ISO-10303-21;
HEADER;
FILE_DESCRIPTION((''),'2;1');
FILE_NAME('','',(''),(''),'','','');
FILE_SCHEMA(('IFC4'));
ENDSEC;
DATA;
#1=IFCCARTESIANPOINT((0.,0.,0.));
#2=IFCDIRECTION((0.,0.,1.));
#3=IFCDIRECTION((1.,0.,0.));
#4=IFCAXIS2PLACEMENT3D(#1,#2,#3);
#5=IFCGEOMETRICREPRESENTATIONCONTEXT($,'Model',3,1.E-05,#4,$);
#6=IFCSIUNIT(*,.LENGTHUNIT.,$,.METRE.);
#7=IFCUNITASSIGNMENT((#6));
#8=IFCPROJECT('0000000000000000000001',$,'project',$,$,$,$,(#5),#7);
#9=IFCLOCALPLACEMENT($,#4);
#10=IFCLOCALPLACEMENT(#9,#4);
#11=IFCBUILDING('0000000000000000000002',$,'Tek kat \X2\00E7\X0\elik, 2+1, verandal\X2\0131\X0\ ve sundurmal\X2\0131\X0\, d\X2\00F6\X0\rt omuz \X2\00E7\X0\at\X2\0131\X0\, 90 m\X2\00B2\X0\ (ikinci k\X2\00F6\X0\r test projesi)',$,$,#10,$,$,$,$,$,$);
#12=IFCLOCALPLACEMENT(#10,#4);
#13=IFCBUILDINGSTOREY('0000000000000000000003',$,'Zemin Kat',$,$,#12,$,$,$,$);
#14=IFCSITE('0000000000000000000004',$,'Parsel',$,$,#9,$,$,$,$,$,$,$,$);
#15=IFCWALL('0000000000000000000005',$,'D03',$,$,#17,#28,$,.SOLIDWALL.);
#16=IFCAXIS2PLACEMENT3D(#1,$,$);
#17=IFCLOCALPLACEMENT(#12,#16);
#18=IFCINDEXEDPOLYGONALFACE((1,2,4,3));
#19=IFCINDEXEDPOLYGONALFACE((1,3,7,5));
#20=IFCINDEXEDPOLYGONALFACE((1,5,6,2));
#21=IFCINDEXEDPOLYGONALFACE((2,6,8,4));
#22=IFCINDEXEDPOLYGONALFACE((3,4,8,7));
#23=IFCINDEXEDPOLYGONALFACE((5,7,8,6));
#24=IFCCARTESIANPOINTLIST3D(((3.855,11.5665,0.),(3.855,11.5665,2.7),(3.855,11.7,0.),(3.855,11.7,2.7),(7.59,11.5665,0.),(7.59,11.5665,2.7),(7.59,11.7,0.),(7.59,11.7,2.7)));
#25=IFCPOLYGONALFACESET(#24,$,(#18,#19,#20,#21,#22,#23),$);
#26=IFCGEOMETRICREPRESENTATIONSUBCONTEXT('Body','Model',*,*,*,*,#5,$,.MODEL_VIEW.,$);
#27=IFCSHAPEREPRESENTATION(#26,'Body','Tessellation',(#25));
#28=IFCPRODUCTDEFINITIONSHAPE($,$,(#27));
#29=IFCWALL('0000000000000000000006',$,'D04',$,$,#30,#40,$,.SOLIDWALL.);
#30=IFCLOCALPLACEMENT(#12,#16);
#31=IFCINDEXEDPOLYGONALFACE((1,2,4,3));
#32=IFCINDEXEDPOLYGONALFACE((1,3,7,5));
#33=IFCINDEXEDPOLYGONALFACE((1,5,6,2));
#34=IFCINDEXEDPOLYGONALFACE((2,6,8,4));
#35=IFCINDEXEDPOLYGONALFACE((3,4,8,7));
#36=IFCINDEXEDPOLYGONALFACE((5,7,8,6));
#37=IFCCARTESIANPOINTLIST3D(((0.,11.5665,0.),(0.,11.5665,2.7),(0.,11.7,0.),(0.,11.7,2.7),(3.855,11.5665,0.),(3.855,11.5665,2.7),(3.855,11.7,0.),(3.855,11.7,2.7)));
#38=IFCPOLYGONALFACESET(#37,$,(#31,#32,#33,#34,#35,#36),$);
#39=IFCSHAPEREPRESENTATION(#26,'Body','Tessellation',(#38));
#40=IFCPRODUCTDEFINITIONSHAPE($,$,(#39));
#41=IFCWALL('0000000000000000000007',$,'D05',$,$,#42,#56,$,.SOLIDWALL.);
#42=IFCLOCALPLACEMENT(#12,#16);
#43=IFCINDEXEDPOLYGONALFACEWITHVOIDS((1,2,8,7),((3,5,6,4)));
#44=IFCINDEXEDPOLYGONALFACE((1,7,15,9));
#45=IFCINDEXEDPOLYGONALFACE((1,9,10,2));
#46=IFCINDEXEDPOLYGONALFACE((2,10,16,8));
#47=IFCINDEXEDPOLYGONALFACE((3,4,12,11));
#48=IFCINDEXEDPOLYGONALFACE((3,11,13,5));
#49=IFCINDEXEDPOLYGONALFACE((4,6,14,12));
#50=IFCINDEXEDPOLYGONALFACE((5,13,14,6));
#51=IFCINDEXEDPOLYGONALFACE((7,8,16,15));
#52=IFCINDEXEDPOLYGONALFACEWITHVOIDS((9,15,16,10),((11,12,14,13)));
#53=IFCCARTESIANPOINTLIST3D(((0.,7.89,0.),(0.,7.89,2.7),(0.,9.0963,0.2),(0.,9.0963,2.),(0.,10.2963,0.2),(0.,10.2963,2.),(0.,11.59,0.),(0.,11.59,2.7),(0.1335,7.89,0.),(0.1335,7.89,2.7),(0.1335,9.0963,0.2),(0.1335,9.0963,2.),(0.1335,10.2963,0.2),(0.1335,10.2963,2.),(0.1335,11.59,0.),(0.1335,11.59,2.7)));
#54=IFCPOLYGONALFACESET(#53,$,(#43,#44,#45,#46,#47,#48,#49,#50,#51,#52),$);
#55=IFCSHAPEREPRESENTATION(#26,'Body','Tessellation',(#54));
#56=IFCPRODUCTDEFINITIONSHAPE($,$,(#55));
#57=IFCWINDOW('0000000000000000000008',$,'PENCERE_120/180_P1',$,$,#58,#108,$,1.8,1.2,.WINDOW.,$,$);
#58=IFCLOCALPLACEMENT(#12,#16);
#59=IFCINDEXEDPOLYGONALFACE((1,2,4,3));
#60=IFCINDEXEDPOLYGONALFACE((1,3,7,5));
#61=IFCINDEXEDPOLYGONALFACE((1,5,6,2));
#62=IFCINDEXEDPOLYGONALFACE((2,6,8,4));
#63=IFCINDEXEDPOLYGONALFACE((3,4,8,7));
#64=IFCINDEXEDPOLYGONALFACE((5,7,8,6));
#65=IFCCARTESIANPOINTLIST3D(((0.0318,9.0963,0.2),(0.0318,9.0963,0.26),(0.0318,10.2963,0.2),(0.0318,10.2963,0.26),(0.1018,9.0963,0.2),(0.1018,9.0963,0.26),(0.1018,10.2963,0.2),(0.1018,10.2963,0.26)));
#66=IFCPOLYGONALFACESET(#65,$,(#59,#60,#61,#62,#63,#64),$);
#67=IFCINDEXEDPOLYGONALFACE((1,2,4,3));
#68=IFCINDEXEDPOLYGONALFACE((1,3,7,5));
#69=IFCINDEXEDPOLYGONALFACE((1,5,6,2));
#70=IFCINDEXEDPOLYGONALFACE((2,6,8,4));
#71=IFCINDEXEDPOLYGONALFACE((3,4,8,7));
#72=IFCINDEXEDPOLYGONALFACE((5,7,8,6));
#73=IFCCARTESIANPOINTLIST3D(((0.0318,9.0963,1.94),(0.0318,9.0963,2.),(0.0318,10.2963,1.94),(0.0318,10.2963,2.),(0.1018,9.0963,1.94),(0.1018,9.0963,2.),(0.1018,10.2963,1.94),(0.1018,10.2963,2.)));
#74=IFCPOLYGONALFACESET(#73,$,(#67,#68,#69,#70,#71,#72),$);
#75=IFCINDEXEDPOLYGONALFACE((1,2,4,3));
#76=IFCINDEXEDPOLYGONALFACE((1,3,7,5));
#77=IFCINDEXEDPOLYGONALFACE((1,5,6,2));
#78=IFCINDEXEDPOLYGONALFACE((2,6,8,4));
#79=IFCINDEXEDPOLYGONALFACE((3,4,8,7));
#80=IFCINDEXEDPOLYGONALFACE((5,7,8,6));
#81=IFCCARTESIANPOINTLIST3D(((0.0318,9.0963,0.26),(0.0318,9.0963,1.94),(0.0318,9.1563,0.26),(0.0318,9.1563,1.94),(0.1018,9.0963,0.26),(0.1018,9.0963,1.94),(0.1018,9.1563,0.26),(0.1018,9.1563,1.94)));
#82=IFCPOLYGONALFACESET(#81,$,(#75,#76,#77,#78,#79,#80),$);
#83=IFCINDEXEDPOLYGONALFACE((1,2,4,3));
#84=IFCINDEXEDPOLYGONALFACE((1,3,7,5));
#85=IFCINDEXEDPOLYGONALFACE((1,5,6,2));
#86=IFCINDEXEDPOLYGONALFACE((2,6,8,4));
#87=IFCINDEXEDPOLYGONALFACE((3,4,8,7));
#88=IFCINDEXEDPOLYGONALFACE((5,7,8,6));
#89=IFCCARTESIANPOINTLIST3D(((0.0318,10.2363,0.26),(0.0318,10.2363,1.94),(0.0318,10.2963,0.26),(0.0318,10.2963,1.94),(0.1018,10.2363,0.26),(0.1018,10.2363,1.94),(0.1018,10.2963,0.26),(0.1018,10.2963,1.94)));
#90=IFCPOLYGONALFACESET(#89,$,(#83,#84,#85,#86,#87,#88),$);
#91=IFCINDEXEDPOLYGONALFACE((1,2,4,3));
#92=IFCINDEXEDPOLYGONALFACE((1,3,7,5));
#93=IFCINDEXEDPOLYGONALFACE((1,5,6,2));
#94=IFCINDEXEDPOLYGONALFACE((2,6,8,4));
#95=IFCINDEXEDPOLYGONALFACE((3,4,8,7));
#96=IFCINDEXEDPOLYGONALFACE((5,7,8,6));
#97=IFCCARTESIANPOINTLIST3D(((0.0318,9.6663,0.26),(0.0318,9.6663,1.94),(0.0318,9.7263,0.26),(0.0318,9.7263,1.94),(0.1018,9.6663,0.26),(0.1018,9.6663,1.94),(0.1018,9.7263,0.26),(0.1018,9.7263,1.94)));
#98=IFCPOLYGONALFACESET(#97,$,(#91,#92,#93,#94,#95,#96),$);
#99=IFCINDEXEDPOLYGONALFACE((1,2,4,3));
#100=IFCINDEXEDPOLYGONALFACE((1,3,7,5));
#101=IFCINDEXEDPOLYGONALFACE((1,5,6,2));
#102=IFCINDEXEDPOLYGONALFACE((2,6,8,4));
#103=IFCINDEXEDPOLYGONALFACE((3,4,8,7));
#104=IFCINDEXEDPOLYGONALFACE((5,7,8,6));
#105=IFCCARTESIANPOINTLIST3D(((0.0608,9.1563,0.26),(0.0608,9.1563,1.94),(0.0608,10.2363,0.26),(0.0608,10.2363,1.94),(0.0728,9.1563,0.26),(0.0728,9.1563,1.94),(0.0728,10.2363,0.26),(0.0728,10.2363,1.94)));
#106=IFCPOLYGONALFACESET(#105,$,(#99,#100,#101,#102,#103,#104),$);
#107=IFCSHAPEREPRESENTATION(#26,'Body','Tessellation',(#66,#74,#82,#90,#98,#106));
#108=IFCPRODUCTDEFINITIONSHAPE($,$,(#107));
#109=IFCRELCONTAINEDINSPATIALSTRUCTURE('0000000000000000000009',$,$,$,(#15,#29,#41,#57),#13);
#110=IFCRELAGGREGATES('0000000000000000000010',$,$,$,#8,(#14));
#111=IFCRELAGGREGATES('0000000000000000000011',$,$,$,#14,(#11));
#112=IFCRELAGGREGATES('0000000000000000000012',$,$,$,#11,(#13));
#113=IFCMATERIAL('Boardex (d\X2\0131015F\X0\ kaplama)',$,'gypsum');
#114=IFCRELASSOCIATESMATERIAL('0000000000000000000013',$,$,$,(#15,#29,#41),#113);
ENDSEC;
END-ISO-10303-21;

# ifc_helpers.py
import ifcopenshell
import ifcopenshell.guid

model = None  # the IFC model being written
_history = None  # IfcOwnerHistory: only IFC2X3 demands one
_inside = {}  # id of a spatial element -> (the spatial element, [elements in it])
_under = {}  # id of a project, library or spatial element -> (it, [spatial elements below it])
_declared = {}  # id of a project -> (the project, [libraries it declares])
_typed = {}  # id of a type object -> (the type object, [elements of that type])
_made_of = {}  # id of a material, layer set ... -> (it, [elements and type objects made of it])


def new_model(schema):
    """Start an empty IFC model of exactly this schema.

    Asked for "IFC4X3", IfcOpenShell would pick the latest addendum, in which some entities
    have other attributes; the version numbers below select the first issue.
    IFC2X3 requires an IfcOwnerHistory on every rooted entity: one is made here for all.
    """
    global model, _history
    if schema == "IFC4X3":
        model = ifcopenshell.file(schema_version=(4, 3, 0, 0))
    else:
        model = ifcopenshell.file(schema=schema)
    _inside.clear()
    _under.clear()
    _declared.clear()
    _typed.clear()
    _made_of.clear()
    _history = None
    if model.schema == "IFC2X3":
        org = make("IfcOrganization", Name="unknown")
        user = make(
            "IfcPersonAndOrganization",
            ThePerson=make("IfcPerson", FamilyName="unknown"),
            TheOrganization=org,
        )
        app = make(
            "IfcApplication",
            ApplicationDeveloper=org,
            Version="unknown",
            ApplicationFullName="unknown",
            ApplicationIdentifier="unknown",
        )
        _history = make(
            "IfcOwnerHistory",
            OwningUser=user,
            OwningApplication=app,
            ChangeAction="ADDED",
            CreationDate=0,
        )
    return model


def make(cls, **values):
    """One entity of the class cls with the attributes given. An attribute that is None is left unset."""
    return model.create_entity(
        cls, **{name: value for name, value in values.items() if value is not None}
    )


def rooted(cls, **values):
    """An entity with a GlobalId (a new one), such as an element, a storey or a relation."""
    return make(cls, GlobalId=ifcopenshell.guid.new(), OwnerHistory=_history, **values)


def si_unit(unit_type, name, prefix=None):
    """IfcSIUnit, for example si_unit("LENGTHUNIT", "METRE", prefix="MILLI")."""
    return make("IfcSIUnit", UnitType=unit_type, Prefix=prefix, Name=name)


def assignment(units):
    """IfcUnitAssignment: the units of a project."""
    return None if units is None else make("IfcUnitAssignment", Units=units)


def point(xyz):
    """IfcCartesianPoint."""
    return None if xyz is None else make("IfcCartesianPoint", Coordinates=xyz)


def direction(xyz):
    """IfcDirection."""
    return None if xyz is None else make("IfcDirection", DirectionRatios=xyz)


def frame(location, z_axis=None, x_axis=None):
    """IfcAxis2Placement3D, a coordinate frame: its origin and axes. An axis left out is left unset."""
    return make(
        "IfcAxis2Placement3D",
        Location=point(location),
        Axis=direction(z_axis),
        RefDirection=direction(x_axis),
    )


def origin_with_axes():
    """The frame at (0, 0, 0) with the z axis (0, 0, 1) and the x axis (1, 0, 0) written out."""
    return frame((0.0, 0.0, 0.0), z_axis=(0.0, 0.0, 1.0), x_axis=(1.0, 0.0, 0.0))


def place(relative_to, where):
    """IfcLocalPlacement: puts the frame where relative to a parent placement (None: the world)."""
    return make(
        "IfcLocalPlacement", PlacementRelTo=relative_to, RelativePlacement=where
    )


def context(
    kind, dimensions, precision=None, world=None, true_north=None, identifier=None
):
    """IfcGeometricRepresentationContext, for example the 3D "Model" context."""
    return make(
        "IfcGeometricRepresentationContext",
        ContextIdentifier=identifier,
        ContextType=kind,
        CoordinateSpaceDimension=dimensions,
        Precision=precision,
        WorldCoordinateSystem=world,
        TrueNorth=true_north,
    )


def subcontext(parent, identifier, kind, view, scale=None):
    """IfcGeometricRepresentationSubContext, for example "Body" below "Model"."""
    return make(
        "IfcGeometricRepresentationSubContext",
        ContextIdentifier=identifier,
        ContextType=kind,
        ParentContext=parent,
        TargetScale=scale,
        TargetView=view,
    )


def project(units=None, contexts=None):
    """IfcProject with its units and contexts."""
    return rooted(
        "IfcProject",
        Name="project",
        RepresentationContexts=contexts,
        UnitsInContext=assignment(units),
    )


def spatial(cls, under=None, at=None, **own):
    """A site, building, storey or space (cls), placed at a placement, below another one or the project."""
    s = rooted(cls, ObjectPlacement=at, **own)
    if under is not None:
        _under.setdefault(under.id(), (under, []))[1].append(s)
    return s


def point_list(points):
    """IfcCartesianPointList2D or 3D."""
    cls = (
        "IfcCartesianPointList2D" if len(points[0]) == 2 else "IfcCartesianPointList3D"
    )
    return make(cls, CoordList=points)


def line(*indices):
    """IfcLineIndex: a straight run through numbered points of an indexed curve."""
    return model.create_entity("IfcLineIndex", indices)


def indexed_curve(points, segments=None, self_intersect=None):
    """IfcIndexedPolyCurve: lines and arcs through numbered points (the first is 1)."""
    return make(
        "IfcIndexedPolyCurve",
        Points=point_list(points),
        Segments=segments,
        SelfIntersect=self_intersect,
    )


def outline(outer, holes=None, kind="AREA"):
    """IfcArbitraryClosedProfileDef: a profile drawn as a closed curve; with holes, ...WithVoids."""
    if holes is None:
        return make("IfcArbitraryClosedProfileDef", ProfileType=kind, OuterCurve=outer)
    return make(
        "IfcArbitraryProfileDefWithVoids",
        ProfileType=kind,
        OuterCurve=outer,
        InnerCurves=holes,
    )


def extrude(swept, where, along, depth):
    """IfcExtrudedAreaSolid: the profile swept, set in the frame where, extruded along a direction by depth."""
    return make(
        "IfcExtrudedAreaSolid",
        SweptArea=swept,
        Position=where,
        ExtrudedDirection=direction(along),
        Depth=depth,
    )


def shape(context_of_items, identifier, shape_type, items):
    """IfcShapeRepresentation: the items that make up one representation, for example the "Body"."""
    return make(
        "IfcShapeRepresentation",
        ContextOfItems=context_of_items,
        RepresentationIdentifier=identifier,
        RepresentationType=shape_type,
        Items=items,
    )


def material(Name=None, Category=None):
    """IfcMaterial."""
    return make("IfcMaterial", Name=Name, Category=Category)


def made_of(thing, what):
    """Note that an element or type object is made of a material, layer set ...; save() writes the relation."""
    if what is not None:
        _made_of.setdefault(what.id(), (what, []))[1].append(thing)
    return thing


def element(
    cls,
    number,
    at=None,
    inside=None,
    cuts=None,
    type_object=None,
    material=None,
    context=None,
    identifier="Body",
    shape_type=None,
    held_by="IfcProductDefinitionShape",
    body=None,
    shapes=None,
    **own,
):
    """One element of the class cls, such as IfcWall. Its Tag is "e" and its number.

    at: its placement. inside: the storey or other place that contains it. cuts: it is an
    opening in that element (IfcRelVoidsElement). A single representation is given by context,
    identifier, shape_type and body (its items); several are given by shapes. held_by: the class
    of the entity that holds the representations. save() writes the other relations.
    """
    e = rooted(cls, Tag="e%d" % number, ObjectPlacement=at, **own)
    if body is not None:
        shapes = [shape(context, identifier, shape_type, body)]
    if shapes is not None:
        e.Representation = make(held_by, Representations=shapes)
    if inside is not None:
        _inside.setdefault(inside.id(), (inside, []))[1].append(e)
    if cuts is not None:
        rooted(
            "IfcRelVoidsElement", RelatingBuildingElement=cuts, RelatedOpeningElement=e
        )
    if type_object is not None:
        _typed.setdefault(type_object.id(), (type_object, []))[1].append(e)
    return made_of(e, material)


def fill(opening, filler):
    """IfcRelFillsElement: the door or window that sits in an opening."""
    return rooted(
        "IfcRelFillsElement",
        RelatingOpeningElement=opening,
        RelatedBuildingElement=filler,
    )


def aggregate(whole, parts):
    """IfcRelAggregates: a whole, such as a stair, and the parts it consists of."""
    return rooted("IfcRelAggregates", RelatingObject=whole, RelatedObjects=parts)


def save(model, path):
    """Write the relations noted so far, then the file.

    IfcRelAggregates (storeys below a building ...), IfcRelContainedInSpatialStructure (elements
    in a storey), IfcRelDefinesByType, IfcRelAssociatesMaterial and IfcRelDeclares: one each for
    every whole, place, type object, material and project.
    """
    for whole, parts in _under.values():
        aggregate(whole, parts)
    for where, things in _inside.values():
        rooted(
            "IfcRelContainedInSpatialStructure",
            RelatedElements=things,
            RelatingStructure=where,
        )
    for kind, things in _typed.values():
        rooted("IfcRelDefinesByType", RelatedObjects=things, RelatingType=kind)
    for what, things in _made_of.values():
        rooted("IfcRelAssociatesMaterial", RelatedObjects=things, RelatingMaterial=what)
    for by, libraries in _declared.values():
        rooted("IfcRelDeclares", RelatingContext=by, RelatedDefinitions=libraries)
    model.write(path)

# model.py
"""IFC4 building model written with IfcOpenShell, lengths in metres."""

from ifc_helpers import new_model, si_unit, frame, origin_with_axes, place, context, subcontext, project, spatial, line, indexed_curve, outline, extrude, material, element, fill, save


model = new_model("IFC4")

# Units and contexts
model_context = context("Model", 3, precision=1e-05, world=origin_with_axes())
body_context = subcontext(model_context, "Body", "Model", "MODEL_VIEW")
ifc_project = project(units=[si_unit("LENGTHUNIT", "METRE")], contexts=[model_context])

# Site, building, storey
site_placement = place(None, origin_with_axes())
site = spatial("IfcSite", under=ifc_project, at=site_placement, Name="Parsel")
building_placement = place(site_placement, origin_with_axes())
building = spatial("IfcBuilding", under=site, at=building_placement, Name="Tek kat çelik, 2+1, verandalı ve sundurmalı, dört omuz çatı, 90 m² (ikinci kör test projesi)")
storey_placement = place(building_placement, origin_with_axes())
storey = spatial("IfcBuildingStorey", under=building, at=storey_placement, Name="Zemin Kat")

# Shared definitions
ifc_material_1 = material(Name="Boardex (dış kaplama)", Category="gypsum")

# Walls
wall_1_placement = place(storey_placement, origin_with_axes())
element("IfcWall", 1, at=wall_1_placement, inside=storey, material=ifc_material_1, Name="D03", PredefinedType="SOLIDWALL", context=body_context, shape_type="SweptSolid", body=[
    extrude(outline(indexed_curve([(0.0, 0.0), (3.735, 0.0), (3.735, 0.1335), (0.0, 0.1335)], segments=[line(1, 2, 3, 4, 1)])), frame((3.855, 11.5665, 0.0), z_axis=(0.0, 0.0, 1.0), x_axis=(1.0, 0.0, 0.0)), (0.0, 0.0, 1.0), 2.7),
])
wall_2_placement = place(storey_placement, origin_with_axes())
element("IfcWall", 2, at=wall_2_placement, inside=storey, material=ifc_material_1, Name="D04", PredefinedType="SOLIDWALL", context=body_context, shape_type="SweptSolid", body=[
    extrude(outline(indexed_curve([(0.0, 0.0), (3.855, 0.0), (3.855, 0.1335), (0.0, 0.1335)], segments=[line(1, 2, 3, 4, 1)])), frame((0.0, 11.5665, 0.0), z_axis=(0.0, 0.0, 1.0), x_axis=(1.0, 0.0, 0.0)), (0.0, 0.0, 1.0), 2.7),
])

# Wall, opening, window
wall_3_placement = place(storey_placement, origin_with_axes())
wall_3 = element("IfcWall", 3, at=wall_3_placement, inside=storey, material=ifc_material_1, Name="D05", PredefinedType="SOLIDWALL", context=body_context, shape_type="SweptSolid", body=[
    extrude(outline(indexed_curve([(0.0, 0.0), (0.1335, 0.0), (0.1335, 3.7), (0.0, 3.7)], segments=[line(1, 2, 3, 4, 1)])), frame((0.0, 7.89, 0.0), z_axis=(0.0, 0.0, 1.0), x_axis=(1.0, 0.0, 0.0)), (0.0, 0.0, 1.0), 2.7),
])
opening_1_placement = place(wall_3_placement, origin_with_axes())
opening_1 = element("IfcOpeningElement", 4, at=opening_1_placement, cuts=wall_3, PredefinedType="OPENING", context=body_context, shape_type="SweptSolid", body=[
    extrude(outline(indexed_curve([(0.0, 0.0), (0.1735, 0.0), (0.1735, 1.2), (0.0, 1.2)], segments=[line(1, 2, 3, 4, 1)])), frame((-0.02, 9.0963, 0.2), z_axis=(0.0, 0.0, 1.0), x_axis=(1.0, 0.0, 0.0)), (0.0, 0.0, 1.0), 1.8),
])
window_1_placement = place(storey_placement, origin_with_axes())
window_1 = element("IfcWindow", 5, at=window_1_placement, inside=storey, Name="PENCERE_120/180_P1", OverallHeight=1.8, OverallWidth=1.2, PredefinedType="WINDOW", context=body_context, shape_type="SweptSolid", body=[
    extrude(outline(indexed_curve([(0.0, 0.0), (0.07, 0.0), (0.07, 1.2), (0.0, 1.2)], segments=[line(1, 2, 3, 4, 1)])), frame((0.0318, 9.0963, 0.2), z_axis=(0.0, 0.0, 1.0), x_axis=(1.0, 0.0, 0.0)), (0.0, 0.0, 1.0), 0.06),
    extrude(outline(indexed_curve([(0.0, 0.0), (0.07, 0.0), (0.07, 1.2), (0.0, 1.2)], segments=[line(1, 2, 3, 4, 1)])), frame((0.0318, 9.0963, 1.94), z_axis=(0.0, 0.0, 1.0), x_axis=(1.0, 0.0, 0.0)), (0.0, 0.0, 1.0), 0.06),
    extrude(outline(indexed_curve([(0.0, 0.0), (0.07, 0.0), (0.07, 0.06), (0.0, 0.06)], segments=[line(1, 2, 3, 4, 1)])), frame((0.0318, 9.0963, 0.26), z_axis=(0.0, 0.0, 1.0), x_axis=(1.0, 0.0, 0.0)), (0.0, 0.0, 1.0), 1.68),
    extrude(outline(indexed_curve([(0.0, 0.0), (0.07, 0.0), (0.07, 0.06), (0.0, 0.06)], segments=[line(1, 2, 3, 4, 1)])), frame((0.0318, 10.2363, 0.26), z_axis=(0.0, 0.0, 1.0), x_axis=(1.0, 0.0, 0.0)), (0.0, 0.0, 1.0), 1.68),
    extrude(outline(indexed_curve([(0.0, 0.0), (0.07, 0.0), (0.07, 0.06), (0.0, 0.06)], segments=[line(1, 2, 3, 4, 1)])), frame((0.0318, 9.6663, 0.26), z_axis=(0.0, 0.0, 1.0), x_axis=(1.0, 0.0, 0.0)), (0.0, 0.0, 1.0), 1.68),
    extrude(outline(indexed_curve([(0.0, 0.0), (0.012, 0.0), (0.012, 1.08), (0.0, 1.08)], segments=[line(1, 2, 3, 4, 1)])), frame((0.0608, 9.1563, 0.26), z_axis=(0.0, 0.0, 1.0), x_axis=(1.0, 0.0, 0.0)), (0.0, 0.0, 1.0), 1.68),
])
fill(opening_1, window_1)

save(model, "model.ifc")
